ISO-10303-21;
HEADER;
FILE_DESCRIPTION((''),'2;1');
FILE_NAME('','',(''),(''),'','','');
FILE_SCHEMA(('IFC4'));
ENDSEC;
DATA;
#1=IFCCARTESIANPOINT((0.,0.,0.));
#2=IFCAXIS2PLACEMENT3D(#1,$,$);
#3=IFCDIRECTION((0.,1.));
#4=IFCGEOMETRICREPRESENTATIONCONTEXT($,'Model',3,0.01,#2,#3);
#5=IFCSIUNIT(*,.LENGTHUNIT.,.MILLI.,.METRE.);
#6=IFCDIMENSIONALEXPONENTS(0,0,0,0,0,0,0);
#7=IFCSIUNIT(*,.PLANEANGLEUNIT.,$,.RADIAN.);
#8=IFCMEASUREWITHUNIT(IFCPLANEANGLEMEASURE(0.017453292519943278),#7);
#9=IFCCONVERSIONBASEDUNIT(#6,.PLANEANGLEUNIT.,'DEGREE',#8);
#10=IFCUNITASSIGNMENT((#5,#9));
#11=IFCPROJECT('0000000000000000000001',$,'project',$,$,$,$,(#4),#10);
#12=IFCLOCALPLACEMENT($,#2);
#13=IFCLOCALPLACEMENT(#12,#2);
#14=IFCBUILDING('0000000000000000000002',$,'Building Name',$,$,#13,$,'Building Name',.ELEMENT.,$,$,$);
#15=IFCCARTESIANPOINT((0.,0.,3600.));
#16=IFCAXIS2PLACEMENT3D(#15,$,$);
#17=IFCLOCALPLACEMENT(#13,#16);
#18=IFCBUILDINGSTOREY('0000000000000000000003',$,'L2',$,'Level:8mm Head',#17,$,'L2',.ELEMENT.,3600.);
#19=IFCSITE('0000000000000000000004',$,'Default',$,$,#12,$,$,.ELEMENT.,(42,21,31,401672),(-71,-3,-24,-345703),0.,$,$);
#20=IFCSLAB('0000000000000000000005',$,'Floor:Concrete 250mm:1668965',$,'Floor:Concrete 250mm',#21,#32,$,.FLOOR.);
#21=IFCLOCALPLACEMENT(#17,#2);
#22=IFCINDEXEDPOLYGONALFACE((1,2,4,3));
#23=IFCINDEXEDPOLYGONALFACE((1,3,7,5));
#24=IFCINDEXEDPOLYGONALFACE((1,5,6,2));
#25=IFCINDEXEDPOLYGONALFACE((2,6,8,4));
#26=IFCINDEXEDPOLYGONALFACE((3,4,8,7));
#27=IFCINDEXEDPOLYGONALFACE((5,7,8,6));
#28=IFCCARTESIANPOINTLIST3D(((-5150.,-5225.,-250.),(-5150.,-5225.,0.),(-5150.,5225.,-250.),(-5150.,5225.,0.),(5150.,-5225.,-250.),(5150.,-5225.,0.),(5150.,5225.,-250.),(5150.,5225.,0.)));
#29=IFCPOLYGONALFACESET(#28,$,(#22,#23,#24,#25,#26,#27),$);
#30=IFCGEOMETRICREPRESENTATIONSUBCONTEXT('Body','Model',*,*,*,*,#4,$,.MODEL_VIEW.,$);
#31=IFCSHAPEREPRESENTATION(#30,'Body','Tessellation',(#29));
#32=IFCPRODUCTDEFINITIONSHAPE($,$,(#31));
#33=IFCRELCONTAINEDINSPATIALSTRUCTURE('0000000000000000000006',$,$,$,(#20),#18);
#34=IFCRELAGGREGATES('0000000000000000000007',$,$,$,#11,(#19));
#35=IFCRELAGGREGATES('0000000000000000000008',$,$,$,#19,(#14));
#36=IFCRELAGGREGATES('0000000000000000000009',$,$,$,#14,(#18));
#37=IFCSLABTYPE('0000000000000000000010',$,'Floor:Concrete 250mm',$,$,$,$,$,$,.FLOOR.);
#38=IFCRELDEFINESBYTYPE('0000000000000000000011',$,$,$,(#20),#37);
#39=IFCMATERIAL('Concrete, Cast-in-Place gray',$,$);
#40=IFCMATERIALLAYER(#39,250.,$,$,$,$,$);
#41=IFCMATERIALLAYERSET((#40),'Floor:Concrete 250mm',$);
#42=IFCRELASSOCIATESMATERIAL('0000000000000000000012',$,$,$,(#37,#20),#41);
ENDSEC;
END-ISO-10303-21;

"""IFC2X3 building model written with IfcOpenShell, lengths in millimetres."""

from ifc_helpers import new_model, entity, si_unit, converted_unit, direction, frame, origin, origin_2d_with_axis, place, context, subcontext, project, spatial, rectangle, extrude, material, layer, layer_set, layer_usage, type_object, element, save


model = new_model("IFC2X3")

# Units and contexts
model_context = context("Model", 3, precision=0.01, world=origin(), true_north=direction((0.0, 1.0)))
body_context = subcontext(model_context, "Body", "Model", "MODEL_VIEW")
ifc_project = project(units=[si_unit("LENGTHUNIT", "METRE", prefix="MILLI"), converted_unit("PLANEANGLEUNIT", "DEGREE", entity("IfcPlaneAngleMeasure", 0.017453292519943278), si_unit("PLANEANGLEUNIT", "RADIAN"), dimensions=[0, 0, 0, 0, 0, 0, 0])], contexts=[model_context])

# Site, building, storey
site_placement = place(None, origin())
site = spatial("IfcSite", under=ifc_project, at=site_placement, Name="Default", CompositionType="ELEMENT", RefLatitude=(42, 21, 31, 401672), RefLongitude=(-71, -3, -24, -345703), RefElevation=0.0)
building_placement = place(site_placement, origin())
building = spatial("IfcBuilding", under=site, at=building_placement, Name="Building Name", LongName="Building Name", CompositionType="ELEMENT")
storey_placement = place(building_placement, frame((0.0, 0.0, 3600.0)))
storey = spatial("IfcBuildingStorey", under=building, at=storey_placement, Name="L2", ObjectType="Level:8mm Head", LongName="L2", CompositionType="ELEMENT", Elevation=3600.0)

# Slab
ifc_material_1 = material(Name="Concrete, Cast-in-Place gray")
ifc_layer = layer(ifc_material_1, 250.0)
ifc_layer_set = layer_set([ifc_layer], Name="Floor:Concrete 250mm")
ifc_layer_usage = layer_usage(ifc_layer_set, "AXIS3", "POSITIVE", 0.0)
slab_type = type_object("IfcSlabType", Name="Floor:Concrete 250mm", PredefinedType="FLOOR", material=ifc_layer_set)
slab_placement = place(storey_placement, origin())
element("IfcSlab", 1, at=slab_placement, inside=storey, type_object=slab_type, material=ifc_layer_usage, Name="Floor:Concrete 250mm:1668965", ObjectType="Floor:Concrete 250mm", PredefinedType="FLOOR", context=body_context, shape_type="SweptSolid", body=[
    extrude(rectangle(XDim=10450.0, YDim=10300.0, at=origin_2d_with_axis()), frame((0.0, 0.0, 0.0), z_axis=(0.0, 0.0, -1.0), x_axis=(0.0, 1.0, 0.0)), (0.0, 0.0, 1.0), 250.0),
])

save(model, "model.ifc")
